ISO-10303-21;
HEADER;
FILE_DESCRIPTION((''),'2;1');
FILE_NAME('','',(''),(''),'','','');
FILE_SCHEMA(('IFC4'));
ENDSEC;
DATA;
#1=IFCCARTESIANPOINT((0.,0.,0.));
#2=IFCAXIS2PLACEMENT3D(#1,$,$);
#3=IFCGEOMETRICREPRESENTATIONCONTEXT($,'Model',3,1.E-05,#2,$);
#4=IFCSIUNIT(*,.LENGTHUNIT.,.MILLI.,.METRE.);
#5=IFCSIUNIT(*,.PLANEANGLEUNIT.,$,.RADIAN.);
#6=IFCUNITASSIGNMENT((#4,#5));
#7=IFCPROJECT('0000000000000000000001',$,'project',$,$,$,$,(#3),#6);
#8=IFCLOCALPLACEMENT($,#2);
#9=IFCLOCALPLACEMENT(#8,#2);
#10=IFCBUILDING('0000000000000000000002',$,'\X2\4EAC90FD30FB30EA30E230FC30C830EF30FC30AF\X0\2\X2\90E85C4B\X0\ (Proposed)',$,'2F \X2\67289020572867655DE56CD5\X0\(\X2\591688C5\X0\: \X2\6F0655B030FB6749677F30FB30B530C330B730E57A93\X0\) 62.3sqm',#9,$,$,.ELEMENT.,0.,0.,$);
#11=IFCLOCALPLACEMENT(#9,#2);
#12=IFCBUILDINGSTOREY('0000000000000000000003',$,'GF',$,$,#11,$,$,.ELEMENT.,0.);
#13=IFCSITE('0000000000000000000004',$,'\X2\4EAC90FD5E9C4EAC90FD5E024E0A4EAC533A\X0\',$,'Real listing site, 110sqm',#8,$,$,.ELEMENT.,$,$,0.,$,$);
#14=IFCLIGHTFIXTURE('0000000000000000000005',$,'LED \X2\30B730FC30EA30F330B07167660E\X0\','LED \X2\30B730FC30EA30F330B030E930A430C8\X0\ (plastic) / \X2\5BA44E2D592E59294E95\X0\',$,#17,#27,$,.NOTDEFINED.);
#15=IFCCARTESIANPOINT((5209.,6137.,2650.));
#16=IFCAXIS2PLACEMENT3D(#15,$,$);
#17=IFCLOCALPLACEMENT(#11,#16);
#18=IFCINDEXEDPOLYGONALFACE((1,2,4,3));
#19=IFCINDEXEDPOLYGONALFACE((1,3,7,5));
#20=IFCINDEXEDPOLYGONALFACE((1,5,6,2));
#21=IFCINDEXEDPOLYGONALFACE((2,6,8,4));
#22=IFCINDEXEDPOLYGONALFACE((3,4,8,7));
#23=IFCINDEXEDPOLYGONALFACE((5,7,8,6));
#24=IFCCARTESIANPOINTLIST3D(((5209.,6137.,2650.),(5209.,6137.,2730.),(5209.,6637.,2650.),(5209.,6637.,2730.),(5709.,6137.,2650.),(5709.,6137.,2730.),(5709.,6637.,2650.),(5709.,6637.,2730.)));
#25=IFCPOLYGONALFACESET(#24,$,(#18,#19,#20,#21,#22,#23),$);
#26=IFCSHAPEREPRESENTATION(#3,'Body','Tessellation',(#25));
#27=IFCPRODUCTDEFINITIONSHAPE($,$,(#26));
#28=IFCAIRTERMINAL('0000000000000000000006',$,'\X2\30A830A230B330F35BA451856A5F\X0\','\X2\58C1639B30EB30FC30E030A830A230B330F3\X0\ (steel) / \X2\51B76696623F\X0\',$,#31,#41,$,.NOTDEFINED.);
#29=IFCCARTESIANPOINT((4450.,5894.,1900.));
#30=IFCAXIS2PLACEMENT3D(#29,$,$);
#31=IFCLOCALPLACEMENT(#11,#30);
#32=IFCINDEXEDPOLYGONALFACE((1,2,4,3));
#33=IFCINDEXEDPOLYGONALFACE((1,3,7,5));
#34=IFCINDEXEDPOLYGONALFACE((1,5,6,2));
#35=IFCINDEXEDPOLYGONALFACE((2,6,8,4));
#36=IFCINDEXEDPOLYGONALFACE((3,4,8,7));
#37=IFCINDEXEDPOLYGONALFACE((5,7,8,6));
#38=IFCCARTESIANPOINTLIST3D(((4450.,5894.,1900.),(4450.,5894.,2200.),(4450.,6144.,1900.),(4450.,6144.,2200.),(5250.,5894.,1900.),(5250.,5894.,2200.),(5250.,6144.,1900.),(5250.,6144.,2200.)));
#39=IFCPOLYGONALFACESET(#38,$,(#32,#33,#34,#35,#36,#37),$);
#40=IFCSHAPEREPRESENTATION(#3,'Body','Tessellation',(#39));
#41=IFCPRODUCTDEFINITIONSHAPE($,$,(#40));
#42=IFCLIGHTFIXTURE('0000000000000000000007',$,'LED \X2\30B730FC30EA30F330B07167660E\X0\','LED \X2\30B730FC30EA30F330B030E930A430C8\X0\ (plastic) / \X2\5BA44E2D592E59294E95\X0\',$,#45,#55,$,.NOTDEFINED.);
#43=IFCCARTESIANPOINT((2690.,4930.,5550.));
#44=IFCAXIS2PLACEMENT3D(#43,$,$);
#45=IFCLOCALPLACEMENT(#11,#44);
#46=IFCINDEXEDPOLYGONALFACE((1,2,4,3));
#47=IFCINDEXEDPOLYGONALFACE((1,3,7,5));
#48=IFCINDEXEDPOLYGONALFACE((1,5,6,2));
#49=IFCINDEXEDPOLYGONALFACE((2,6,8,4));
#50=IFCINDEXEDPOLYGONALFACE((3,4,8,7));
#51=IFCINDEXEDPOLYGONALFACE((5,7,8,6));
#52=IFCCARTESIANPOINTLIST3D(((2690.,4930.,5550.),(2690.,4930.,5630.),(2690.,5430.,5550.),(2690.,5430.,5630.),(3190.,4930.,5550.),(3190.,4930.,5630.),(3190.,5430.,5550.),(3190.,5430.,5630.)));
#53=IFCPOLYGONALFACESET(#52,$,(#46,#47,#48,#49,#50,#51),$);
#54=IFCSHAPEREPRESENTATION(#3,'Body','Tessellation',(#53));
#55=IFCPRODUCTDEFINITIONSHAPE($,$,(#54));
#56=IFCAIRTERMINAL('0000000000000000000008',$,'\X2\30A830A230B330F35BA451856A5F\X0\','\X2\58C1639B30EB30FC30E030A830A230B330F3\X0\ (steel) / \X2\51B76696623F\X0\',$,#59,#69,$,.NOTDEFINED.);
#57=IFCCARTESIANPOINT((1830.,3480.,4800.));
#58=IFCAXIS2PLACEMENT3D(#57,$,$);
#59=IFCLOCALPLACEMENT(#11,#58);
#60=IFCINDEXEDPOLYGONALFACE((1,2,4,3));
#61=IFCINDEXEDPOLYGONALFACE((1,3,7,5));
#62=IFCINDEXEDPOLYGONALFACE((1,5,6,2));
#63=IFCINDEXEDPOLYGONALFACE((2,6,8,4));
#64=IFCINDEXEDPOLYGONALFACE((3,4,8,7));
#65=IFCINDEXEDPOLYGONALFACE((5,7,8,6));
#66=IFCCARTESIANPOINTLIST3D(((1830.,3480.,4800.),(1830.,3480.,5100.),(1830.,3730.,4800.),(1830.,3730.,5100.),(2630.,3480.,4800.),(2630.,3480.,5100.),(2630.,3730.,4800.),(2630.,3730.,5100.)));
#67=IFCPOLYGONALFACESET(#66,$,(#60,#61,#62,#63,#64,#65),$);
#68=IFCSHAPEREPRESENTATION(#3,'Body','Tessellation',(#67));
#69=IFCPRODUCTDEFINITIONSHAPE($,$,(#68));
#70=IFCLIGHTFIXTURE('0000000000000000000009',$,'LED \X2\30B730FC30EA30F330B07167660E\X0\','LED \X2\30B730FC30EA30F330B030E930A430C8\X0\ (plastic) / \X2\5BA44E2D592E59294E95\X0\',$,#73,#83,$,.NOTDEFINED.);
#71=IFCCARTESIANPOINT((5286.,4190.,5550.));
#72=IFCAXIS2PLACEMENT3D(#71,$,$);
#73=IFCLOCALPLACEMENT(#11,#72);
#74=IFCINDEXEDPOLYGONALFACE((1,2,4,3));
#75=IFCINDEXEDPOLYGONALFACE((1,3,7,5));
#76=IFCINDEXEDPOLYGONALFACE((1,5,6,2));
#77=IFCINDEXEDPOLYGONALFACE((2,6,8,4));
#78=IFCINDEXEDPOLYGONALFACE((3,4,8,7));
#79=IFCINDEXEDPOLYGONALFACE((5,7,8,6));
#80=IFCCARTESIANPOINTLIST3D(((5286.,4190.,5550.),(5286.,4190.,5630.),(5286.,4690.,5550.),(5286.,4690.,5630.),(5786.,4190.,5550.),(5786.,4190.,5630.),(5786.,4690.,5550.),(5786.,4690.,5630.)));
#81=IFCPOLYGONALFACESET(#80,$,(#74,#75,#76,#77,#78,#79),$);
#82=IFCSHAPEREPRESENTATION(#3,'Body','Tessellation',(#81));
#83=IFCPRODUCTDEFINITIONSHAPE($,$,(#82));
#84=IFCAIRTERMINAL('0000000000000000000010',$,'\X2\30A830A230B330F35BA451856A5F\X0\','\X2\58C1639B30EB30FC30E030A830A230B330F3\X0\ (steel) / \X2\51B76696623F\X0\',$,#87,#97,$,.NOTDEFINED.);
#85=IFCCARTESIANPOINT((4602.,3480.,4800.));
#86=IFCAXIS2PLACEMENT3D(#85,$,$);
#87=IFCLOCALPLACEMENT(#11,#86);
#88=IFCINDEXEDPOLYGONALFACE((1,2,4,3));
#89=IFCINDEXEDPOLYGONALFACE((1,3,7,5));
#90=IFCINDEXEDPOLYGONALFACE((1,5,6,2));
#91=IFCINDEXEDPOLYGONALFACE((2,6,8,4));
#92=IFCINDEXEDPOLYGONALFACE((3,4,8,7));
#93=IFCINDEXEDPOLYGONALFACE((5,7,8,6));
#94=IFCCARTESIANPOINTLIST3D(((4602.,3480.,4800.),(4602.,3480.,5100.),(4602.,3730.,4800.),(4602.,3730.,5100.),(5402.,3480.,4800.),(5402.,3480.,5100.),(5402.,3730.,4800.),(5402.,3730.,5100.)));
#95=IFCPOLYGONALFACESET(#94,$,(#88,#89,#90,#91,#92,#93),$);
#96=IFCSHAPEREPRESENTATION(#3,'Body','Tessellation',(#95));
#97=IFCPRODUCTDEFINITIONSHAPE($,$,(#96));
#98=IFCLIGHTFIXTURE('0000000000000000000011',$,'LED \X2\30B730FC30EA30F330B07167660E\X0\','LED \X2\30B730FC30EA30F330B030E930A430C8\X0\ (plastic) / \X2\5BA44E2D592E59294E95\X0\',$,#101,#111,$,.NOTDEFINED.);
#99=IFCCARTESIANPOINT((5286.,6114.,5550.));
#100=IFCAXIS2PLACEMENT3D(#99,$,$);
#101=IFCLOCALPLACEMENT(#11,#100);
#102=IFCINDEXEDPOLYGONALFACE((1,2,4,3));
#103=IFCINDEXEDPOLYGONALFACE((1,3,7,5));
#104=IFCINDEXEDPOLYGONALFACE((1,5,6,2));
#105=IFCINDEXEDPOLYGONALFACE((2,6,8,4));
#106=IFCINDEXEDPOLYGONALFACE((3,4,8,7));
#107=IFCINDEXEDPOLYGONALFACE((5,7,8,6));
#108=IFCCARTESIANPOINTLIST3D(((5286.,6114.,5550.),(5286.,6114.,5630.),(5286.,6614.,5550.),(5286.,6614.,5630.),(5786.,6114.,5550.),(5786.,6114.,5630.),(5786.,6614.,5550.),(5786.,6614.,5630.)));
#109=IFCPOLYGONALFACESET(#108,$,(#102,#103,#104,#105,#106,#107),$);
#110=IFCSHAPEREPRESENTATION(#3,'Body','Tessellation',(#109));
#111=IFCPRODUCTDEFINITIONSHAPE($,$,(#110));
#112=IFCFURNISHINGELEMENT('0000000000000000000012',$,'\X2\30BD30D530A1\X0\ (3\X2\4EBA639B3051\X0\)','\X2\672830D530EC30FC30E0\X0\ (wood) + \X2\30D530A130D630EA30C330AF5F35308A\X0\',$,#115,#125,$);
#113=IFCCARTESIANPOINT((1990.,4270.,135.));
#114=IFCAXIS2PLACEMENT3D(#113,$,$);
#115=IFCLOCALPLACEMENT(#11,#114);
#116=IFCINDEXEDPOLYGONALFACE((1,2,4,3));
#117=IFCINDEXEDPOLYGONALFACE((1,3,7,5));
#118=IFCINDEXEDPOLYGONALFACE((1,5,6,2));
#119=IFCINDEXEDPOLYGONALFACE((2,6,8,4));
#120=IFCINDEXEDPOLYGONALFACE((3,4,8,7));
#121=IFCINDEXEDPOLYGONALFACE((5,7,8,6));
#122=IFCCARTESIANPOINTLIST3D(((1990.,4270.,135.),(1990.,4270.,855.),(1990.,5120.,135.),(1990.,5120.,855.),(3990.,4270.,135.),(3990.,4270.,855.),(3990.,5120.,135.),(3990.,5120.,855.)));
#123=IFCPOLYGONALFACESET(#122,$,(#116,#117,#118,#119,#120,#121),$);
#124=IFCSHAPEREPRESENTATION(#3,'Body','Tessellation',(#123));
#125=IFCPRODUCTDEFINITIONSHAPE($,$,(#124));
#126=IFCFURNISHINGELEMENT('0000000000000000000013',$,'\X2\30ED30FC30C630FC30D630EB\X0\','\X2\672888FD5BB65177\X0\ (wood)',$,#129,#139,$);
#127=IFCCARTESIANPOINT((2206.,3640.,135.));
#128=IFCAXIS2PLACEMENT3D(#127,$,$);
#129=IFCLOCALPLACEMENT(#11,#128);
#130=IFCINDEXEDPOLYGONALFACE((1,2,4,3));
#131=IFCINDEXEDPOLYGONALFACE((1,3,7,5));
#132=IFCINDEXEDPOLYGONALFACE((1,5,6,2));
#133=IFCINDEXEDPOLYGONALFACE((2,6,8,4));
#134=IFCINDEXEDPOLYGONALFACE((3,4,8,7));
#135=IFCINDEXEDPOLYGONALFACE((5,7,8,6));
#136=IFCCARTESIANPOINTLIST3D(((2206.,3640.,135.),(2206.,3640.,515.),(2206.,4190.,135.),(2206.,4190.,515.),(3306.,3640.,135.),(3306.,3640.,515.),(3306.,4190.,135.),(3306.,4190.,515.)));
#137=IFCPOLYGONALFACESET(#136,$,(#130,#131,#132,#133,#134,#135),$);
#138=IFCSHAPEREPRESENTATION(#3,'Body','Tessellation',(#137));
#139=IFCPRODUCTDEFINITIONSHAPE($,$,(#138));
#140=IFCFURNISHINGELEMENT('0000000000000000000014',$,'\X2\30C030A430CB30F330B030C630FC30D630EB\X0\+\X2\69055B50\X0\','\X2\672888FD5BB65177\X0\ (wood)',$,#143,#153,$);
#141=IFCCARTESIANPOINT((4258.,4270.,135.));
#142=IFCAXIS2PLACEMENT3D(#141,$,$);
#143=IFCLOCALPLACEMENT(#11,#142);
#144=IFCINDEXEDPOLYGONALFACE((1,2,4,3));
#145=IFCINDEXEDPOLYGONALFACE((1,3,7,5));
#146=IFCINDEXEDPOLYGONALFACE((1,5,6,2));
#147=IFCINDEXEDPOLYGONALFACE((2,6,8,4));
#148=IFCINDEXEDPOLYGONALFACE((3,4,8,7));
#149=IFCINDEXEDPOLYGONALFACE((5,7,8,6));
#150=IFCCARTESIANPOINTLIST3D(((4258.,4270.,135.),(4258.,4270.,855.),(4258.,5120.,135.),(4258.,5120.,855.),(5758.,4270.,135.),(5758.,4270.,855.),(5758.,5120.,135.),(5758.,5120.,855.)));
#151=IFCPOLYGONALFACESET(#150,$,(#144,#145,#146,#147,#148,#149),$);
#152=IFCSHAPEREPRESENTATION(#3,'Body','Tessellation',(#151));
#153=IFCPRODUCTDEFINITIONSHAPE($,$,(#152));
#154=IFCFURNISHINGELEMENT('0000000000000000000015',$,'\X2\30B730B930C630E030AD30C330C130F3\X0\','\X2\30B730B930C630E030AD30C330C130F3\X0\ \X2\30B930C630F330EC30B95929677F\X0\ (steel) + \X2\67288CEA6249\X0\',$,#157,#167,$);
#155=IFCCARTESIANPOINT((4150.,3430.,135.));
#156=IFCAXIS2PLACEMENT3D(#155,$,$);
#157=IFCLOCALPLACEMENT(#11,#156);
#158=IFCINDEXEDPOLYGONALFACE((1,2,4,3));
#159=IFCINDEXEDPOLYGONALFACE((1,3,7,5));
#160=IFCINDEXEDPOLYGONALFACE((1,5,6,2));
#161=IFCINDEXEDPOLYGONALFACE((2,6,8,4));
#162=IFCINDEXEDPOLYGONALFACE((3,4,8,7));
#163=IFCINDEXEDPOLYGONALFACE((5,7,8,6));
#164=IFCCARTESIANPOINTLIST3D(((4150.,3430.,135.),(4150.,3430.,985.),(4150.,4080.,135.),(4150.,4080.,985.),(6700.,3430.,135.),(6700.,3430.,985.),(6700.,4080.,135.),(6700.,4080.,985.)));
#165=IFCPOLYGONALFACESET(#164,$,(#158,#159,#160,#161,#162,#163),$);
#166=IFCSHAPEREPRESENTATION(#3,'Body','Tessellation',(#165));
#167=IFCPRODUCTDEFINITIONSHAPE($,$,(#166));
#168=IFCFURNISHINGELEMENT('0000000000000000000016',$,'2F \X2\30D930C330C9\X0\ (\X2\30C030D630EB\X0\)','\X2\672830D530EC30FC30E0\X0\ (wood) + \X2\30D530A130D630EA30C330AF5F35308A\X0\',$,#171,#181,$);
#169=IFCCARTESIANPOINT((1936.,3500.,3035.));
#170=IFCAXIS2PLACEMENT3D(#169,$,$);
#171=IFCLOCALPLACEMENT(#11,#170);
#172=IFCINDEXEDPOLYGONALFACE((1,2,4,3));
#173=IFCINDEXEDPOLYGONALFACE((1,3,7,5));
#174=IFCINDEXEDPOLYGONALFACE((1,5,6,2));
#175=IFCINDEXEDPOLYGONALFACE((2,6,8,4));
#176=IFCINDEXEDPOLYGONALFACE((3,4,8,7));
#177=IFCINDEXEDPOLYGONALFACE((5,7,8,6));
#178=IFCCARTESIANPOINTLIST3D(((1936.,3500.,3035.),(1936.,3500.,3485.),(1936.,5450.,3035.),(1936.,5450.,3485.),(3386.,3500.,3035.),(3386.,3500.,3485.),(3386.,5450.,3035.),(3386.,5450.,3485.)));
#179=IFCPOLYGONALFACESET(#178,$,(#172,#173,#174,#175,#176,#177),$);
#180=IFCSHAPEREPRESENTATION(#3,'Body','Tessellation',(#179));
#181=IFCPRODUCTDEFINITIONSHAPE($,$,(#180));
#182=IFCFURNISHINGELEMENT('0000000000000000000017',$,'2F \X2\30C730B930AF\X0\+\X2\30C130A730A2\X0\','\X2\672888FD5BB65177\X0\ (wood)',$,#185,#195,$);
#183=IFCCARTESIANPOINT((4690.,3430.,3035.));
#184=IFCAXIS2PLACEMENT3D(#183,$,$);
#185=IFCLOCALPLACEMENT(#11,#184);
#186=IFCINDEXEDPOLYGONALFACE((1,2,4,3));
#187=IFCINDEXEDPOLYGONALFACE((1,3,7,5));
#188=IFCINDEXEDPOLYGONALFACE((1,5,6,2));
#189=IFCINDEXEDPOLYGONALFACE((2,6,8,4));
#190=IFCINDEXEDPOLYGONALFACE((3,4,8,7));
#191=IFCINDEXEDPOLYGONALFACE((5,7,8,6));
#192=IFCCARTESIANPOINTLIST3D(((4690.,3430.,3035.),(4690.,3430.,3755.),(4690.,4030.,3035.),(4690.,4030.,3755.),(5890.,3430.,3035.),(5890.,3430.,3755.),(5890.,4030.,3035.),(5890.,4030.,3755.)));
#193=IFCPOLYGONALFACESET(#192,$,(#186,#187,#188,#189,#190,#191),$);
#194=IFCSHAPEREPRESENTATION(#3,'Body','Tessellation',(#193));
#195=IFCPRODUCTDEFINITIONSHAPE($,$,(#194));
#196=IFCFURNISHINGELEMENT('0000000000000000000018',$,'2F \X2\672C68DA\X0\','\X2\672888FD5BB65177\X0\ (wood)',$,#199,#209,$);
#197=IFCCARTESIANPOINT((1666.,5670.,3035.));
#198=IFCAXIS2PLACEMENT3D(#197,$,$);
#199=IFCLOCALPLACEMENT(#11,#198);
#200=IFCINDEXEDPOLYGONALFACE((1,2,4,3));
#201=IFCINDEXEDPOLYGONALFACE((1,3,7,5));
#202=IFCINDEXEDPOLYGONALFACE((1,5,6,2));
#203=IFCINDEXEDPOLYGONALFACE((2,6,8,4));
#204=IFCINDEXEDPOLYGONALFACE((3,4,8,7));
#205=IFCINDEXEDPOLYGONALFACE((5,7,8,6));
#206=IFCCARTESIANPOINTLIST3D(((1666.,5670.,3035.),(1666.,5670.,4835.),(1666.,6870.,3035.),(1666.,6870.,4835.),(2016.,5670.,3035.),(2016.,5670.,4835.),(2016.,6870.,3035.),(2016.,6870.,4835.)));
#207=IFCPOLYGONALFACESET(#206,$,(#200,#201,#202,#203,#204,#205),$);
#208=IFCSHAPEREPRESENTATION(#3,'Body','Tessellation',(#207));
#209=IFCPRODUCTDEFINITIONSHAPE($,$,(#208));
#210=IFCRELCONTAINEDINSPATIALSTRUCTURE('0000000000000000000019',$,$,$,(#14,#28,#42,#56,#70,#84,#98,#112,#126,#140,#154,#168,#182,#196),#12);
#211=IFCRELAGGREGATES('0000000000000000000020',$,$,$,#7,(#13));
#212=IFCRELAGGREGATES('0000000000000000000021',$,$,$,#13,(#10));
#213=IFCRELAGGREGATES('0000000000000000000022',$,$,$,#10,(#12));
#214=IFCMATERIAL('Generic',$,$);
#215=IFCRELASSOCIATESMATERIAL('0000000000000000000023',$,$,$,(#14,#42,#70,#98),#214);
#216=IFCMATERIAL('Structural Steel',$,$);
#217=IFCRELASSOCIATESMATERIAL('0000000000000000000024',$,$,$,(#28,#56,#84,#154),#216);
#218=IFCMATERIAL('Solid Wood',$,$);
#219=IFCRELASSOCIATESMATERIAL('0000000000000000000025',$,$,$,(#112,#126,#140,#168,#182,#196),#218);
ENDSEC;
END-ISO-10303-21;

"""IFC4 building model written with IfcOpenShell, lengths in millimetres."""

from ifc_helpers import new_model, si_unit, frame, frame_2d, origin, place, context, project, spatial, rectangle, extrude, material, element, save


model = new_model("IFC4")

# Units and contexts
model_context = context("Model", 3, precision=1e-05, world=origin())
ifc_project = project(units=[si_unit("LENGTHUNIT", "METRE", prefix="MILLI"), si_unit("PLANEANGLEUNIT", "RADIAN")], contexts=[model_context])

# Site, building, storey
site_placement = place(None, origin())
site = spatial("IfcSite", under=ifc_project, at=site_placement, Name="京都府京都市上京区", ObjectType="Real listing site, 110sqm", CompositionType="ELEMENT", RefElevation=0.0)
building_placement = place(site_placement, origin())
building = spatial("IfcBuilding", under=site, at=building_placement, Name="京都・リモートワーク2部屋 (Proposed)", ObjectType="2F 木造在来工法(外装: 漆喰・杉板・サッシュ窓) 62.3sqm", CompositionType="ELEMENT", ElevationOfRefHeight=0.0, ElevationOfTerrain=0.0)
storey_placement = place(building_placement, origin())
storey = spatial("IfcBuildingStorey", under=building, at=storey_placement, Name="GF", CompositionType="ELEMENT", Elevation=0.0)

# Shared definitions
ifc_material_1 = material(Name="Solid Wood")

# Shared definitions
ifc_material_2 = material(Name="Structural Steel")

# Shared definitions
ifc_material_3 = material(Name="Generic")

# Light fixture
light_fixture_1_placement = place(storey_placement, frame((5209.0, 6137.0, 2650.0)))
element("IfcLightFixture", 1, at=light_fixture_1_placement, inside=storey, material=ifc_material_3, Name="LED シーリング照明", Description="LED シーリングライト (plastic) / 室中央天井", PredefinedType="NOTDEFINED", context=model_context, shape_type="SweptSolid", body=[
    extrude(rectangle(XDim=500.0, YDim=500.0, at=frame_2d((250.0, 250.0))), frame((5209.0, 6137.0, 2650.0)), (0.0, 0.0, 1.0), 80.0),
])

# Air terminal
air_terminal_1_placement = place(storey_placement, frame((4450.0, 5894.0, 1900.0)))
element("IfcAirTerminal", 2, at=air_terminal_1_placement, inside=storey, material=ifc_material_2, Name="エアコン室内機", Description="壁掛ルームエアコン (steel) / 冷暖房", PredefinedType="NOTDEFINED", context=model_context, shape_type="SweptSolid", body=[
    extrude(rectangle(XDim=800.0, YDim=250.0, at=frame_2d((400.0, 125.0))), frame((4450.0, 5894.0, 1900.0)), (0.0, 0.0, 1.0), 300.0),
])

# Light fixture
light_fixture_2_placement = place(storey_placement, frame((2690.0, 4930.0, 5550.0)))
element("IfcLightFixture", 3, at=light_fixture_2_placement, inside=storey, material=ifc_material_3, Name="LED シーリング照明", Description="LED シーリングライト (plastic) / 室中央天井", PredefinedType="NOTDEFINED", context=model_context, shape_type="SweptSolid", body=[
    extrude(rectangle(XDim=500.0, YDim=500.0, at=frame_2d((250.0, 250.0))), frame((2690.0, 4930.0, 5550.0)), (0.0, 0.0, 1.0), 80.0),
])

# Air terminal
air_terminal_2_placement = place(storey_placement, frame((1830.0, 3480.0, 4800.0)))
element("IfcAirTerminal", 4, at=air_terminal_2_placement, inside=storey, material=ifc_material_2, Name="エアコン室内機", Description="壁掛ルームエアコン (steel) / 冷暖房", PredefinedType="NOTDEFINED", context=model_context, shape_type="SweptSolid", body=[
    extrude(rectangle(XDim=800.0, YDim=250.0, at=frame_2d((400.0, 125.0))), frame((1830.0, 3480.0, 4800.0)), (0.0, 0.0, 1.0), 300.0),
])

# Light fixture
light_fixture_3_placement = place(storey_placement, frame((5286.0, 4190.0, 5550.0)))
element("IfcLightFixture", 5, at=light_fixture_3_placement, inside=storey, material=ifc_material_3, Name="LED シーリング照明", Description="LED シーリングライト (plastic) / 室中央天井", PredefinedType="NOTDEFINED", context=model_context, shape_type="SweptSolid", body=[
    extrude(rectangle(XDim=500.0, YDim=500.0, at=frame_2d((250.0, 250.0))), frame((5286.0, 4190.0, 5550.0)), (0.0, 0.0, 1.0), 80.0),
])

# Air terminal
air_terminal_3_placement = place(storey_placement, frame((4602.0, 3480.0, 4800.0)))
element("IfcAirTerminal", 6, at=air_terminal_3_placement, inside=storey, material=ifc_material_2, Name="エアコン室内機", Description="壁掛ルームエアコン (steel) / 冷暖房", PredefinedType="NOTDEFINED", context=model_context, shape_type="SweptSolid", body=[
    extrude(rectangle(XDim=800.0, YDim=250.0, at=frame_2d((400.0, 125.0))), frame((4602.0, 3480.0, 4800.0)), (0.0, 0.0, 1.0), 300.0),
])

# Light fixture
light_fixture_4_placement = place(storey_placement, frame((5286.0, 6114.0, 5550.0)))
element("IfcLightFixture", 7, at=light_fixture_4_placement, inside=storey, material=ifc_material_3, Name="LED シーリング照明", Description="LED シーリングライト (plastic) / 室中央天井", PredefinedType="NOTDEFINED", context=model_context, shape_type="SweptSolid", body=[
    extrude(rectangle(XDim=500.0, YDim=500.0, at=frame_2d((250.0, 250.0))), frame((5286.0, 6114.0, 5550.0)), (0.0, 0.0, 1.0), 80.0),
])

# Furnishing elements
furnishing_1_placement = place(storey_placement, frame((1990.0, 4270.0, 135.0)))
element("IfcFurnishingElement", 8, at=furnishing_1_placement, inside=storey, material=ifc_material_1, Name="ソファ (3人掛け)", Description="木フレーム (wood) + ファブリック張り", context=model_context, shape_type="SweptSolid", body=[
    extrude(rectangle(XDim=2000.0, YDim=850.0, at=frame_2d((1000.0, 425.0))), frame((1990.0, 4270.0, 135.0)), (0.0, 0.0, 1.0), 720.0),
])
furnishing_2_placement = place(storey_placement, frame((2206.0, 3640.0, 135.0)))
element("IfcFurnishingElement", 9, at=furnishing_2_placement, inside=storey, material=ifc_material_1, Name="ローテーブル", Description="木製家具 (wood)", context=model_context, shape_type="SweptSolid", body=[
    extrude(rectangle(XDim=1100.0, YDim=550.0, at=frame_2d((550.0, 275.0))), frame((2206.0, 3640.0, 135.0)), (0.0, 0.0, 1.0), 380.0),
])
furnishing_3_placement = place(storey_placement, frame((4258.0, 4270.0, 135.0)))
element("IfcFurnishingElement", 10, at=furnishing_3_placement, inside=storey, material=ifc_material_1, Name="ダイニングテーブル+椅子", Description="木製家具 (wood)", context=model_context, shape_type="SweptSolid", body=[
    extrude(rectangle(XDim=1500.0, YDim=850.0, at=frame_2d((750.0, 425.0))), frame((4258.0, 4270.0, 135.0)), (0.0, 0.0, 1.0), 720.0),
])
furnishing_4_placement = place(storey_placement, frame((4150.0, 3430.0, 135.0)))
element("IfcFurnishingElement", 11, at=furnishing_4_placement, inside=storey, material=ifc_material_2, Name="システムキッチン", Description="システムキッチン ステンレス天板 (steel) + 木質扉", context=model_context, shape_type="SweptSolid", body=[
    extrude(rectangle(XDim=2550.0, YDim=650.0, at=frame_2d((1275.0, 325.0))), frame((4150.0, 3430.0, 135.0)), (0.0, 0.0, 1.0), 850.0),
])
furnishing_5_placement = place(storey_placement, frame((1936.0, 3500.0, 3035.0)))
element("IfcFurnishingElement", 12, at=furnishing_5_placement, inside=storey, material=ifc_material_1, Name="2F ベッド (ダブル)", Description="木フレーム (wood) + ファブリック張り", context=model_context, shape_type="SweptSolid", body=[
    extrude(rectangle(XDim=1450.0, YDim=1950.0, at=frame_2d((725.0, 975.0))), frame((1936.0, 3500.0, 3035.0)), (0.0, 0.0, 1.0), 450.0),
])
furnishing_6_placement = place(storey_placement, frame((4690.0, 3430.0, 3035.0)))
element("IfcFurnishingElement", 13, at=furnishing_6_placement, inside=storey, material=ifc_material_1, Name="2F デスク+チェア", Description="木製家具 (wood)", context=model_context, shape_type="SweptSolid", body=[
    extrude(rectangle(XDim=1200.0, YDim=600.0, at=frame_2d((600.0, 300.0))), frame((4690.0, 3430.0, 3035.0)), (0.0, 0.0, 1.0), 720.0),
])
furnishing_7_placement = place(storey_placement, frame((1666.0, 5670.0, 3035.0)))
element("IfcFurnishingElement", 14, at=furnishing_7_placement, inside=storey, material=ifc_material_1, Name="2F 本棚", Description="木製家具 (wood)", context=model_context, shape_type="SweptSolid", body=[
    extrude(rectangle(XDim=350.0, YDim=1200.0, at=frame_2d((175.0, 600.0))), frame((1666.0, 5670.0, 3035.0)), (0.0, 0.0, 1.0), 1800.0),
])

save(model, "model.ifc")
